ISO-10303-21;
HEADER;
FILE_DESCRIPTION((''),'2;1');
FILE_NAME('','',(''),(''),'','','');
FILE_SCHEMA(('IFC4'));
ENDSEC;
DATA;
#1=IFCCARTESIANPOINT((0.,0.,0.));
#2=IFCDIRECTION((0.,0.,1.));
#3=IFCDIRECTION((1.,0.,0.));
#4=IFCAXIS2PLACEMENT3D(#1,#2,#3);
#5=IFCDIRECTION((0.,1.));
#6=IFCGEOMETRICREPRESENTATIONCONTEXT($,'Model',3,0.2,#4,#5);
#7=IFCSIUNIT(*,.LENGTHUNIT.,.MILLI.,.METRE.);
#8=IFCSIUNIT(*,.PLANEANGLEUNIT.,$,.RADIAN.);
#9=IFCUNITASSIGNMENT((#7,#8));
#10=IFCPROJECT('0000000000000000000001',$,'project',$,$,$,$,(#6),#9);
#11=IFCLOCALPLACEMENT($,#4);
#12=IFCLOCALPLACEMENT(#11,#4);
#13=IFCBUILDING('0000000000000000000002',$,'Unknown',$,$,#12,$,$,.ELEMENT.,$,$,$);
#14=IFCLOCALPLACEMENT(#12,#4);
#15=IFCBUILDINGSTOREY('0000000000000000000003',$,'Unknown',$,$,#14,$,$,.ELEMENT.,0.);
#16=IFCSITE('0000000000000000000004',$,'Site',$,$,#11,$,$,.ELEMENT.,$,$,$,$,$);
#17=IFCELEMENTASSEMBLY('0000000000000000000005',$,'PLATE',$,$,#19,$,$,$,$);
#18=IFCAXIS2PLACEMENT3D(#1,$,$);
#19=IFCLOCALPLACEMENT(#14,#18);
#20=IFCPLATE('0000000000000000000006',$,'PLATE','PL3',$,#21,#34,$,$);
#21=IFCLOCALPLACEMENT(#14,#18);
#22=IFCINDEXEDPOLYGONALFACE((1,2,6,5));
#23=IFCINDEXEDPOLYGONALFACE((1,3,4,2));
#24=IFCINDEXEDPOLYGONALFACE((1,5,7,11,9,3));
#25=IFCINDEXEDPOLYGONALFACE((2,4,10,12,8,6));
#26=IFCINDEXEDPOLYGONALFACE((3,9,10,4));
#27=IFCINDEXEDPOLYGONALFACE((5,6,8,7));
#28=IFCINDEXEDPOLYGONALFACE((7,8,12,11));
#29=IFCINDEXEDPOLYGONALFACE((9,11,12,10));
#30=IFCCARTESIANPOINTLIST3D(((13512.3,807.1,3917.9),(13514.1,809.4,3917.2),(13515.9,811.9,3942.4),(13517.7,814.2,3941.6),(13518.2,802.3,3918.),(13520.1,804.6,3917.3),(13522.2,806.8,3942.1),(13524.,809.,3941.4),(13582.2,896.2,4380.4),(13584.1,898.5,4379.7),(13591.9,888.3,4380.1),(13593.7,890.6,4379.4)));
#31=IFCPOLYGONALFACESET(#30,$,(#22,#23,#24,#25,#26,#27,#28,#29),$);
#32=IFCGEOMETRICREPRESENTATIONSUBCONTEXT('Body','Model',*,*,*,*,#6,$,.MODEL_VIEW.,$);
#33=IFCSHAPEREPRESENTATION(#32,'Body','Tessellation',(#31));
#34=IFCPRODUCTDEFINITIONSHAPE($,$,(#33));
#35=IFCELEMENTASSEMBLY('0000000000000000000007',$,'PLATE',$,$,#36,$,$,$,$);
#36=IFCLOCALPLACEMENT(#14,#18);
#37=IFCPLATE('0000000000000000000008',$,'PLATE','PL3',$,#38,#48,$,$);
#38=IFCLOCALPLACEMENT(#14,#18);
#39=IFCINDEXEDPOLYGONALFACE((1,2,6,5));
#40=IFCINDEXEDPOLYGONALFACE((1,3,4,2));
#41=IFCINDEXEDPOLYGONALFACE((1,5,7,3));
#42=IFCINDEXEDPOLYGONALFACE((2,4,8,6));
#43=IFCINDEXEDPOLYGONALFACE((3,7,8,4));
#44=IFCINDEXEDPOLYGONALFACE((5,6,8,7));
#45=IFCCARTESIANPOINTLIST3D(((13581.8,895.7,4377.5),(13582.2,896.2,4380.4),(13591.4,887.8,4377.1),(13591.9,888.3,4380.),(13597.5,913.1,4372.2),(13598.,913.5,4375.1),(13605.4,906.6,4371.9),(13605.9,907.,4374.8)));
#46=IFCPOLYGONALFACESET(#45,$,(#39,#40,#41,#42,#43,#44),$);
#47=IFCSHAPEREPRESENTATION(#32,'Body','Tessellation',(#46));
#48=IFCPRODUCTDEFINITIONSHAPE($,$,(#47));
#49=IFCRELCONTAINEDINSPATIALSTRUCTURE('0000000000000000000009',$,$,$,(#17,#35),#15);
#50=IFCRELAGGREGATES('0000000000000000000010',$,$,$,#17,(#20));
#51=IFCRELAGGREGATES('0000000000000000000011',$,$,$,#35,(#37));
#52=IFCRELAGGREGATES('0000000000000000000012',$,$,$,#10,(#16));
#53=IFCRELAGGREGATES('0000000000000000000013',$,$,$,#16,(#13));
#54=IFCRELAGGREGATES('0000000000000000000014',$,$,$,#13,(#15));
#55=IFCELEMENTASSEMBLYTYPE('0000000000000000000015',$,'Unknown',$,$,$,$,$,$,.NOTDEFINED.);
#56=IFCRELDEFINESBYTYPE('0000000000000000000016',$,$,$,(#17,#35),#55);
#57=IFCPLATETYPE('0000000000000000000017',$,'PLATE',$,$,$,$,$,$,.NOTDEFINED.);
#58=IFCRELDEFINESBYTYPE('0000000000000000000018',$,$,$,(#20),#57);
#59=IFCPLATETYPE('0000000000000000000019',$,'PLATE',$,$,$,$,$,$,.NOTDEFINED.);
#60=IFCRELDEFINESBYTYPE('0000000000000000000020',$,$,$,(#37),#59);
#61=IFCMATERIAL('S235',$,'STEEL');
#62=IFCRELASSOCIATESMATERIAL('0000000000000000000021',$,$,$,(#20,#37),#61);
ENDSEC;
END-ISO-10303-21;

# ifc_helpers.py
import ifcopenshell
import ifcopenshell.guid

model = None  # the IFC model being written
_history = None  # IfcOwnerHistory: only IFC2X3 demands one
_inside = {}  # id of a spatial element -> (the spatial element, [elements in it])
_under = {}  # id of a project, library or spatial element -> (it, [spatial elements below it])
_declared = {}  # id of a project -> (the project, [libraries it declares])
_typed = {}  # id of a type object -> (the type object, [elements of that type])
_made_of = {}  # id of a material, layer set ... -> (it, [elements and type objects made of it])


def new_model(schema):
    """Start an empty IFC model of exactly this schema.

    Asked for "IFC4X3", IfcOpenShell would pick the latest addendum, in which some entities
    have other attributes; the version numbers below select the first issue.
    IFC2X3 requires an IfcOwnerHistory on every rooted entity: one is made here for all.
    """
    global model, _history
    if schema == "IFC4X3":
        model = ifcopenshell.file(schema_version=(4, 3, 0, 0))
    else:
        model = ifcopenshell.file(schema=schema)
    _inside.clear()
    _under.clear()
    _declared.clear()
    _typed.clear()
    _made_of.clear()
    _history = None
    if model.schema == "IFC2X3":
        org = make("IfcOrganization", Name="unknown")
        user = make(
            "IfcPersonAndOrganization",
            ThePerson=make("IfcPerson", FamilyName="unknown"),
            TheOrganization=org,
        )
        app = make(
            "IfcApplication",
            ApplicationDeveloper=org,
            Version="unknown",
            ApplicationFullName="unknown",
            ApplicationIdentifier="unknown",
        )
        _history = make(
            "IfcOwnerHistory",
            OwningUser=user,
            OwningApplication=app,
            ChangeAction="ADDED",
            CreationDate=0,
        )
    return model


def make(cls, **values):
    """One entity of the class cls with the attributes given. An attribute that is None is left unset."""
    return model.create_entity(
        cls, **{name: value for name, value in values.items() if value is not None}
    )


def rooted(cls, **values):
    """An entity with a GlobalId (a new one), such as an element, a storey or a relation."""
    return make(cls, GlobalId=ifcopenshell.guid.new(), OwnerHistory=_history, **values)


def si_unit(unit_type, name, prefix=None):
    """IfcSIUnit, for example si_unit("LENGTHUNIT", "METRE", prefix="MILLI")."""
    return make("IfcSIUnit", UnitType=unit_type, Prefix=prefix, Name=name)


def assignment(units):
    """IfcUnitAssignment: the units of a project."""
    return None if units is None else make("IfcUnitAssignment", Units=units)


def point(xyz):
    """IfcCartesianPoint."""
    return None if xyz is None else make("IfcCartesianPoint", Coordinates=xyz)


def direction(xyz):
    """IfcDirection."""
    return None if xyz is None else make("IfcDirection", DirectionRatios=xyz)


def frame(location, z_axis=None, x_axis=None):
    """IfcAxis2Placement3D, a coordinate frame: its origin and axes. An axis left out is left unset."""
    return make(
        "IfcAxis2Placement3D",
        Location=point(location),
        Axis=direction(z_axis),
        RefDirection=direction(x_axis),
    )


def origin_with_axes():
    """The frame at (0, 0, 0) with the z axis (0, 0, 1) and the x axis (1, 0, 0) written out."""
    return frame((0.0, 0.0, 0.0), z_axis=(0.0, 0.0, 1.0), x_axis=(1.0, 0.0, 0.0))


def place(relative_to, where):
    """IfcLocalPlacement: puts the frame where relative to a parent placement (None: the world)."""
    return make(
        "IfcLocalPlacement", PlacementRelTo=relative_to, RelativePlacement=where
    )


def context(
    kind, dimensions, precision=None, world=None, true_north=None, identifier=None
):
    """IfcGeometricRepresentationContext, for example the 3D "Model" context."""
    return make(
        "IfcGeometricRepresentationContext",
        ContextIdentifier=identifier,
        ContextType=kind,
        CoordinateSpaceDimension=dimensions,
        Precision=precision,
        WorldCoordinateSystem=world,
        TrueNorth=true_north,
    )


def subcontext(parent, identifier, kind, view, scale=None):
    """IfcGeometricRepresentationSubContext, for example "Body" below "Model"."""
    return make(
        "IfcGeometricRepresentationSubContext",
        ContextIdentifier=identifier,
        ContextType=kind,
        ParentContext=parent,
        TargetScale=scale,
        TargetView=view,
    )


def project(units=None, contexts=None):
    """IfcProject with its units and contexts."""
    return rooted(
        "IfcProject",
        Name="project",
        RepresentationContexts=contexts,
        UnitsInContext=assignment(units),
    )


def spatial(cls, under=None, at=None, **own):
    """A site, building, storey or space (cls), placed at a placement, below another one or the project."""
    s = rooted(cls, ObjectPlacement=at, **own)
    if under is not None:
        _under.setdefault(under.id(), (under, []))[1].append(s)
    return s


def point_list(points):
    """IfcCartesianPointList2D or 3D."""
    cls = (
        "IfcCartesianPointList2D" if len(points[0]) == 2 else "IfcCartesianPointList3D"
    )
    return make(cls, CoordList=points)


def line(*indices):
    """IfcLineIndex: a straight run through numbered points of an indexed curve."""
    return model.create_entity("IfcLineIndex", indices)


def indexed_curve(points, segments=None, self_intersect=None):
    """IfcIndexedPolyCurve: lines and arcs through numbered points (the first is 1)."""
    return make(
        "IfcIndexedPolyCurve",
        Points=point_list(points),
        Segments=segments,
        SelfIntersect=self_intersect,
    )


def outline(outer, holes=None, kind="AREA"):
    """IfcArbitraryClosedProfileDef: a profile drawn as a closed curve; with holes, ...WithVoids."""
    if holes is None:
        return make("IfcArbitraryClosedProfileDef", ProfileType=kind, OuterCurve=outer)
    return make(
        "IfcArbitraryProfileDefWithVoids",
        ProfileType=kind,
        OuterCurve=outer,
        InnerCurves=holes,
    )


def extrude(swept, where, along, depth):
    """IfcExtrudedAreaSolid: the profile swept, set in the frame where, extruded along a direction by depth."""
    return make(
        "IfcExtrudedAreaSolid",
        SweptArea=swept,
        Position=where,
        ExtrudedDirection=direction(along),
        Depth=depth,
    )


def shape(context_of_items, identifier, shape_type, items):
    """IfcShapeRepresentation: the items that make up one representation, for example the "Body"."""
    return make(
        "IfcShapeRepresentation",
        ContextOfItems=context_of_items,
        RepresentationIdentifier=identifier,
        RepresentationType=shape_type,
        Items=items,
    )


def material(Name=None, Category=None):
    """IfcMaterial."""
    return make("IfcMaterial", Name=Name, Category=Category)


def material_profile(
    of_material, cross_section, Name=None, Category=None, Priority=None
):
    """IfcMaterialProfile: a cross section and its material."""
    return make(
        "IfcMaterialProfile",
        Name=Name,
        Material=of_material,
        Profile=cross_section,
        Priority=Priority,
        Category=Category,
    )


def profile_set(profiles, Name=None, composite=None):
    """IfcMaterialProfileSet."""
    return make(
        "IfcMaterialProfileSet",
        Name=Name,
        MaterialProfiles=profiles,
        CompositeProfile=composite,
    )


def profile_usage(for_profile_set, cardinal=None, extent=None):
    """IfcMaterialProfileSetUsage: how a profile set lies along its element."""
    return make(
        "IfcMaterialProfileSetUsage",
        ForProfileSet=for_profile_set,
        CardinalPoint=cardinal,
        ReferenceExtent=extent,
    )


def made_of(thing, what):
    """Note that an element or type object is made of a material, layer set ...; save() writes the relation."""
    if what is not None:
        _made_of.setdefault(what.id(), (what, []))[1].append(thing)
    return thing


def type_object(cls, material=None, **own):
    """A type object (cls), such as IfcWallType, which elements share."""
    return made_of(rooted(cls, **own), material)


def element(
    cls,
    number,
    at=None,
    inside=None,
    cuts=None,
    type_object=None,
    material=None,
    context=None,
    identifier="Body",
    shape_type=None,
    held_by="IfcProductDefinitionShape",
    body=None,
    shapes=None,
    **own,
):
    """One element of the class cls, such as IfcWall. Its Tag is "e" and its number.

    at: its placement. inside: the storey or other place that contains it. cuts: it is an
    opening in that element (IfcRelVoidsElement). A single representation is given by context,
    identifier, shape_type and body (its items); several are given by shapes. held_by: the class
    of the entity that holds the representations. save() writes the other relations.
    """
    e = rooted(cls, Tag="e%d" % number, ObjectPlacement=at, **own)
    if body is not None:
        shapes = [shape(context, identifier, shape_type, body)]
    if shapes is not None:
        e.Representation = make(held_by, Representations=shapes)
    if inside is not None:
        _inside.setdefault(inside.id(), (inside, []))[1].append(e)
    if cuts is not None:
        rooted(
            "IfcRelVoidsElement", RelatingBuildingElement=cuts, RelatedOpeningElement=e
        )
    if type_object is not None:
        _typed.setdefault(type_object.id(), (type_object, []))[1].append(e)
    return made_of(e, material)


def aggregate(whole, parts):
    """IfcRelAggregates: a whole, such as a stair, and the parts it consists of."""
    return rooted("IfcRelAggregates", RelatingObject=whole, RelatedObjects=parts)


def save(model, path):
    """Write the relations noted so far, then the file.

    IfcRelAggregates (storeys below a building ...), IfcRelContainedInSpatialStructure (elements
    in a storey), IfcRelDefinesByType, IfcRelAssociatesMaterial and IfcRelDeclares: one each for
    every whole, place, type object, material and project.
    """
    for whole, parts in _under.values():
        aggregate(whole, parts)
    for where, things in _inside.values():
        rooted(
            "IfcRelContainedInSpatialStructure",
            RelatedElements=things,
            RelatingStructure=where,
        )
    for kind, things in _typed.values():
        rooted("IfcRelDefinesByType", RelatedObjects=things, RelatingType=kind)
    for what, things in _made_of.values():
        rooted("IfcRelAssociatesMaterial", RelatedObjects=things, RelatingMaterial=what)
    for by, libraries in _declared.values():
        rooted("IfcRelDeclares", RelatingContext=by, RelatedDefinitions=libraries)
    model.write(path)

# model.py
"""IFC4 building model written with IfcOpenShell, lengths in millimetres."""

from ifc_helpers import new_model, si_unit, direction, frame, origin_with_axes, place, context, subcontext, project, spatial, line, indexed_curve, outline, extrude, material, material_profile, profile_set, profile_usage, type_object, element, aggregate, save


model = new_model("IFC4")

# Units and contexts
model_context = context("Model", 3, precision=0.2, world=origin_with_axes(), true_north=direction((0.0, 1.0)))
body_context = subcontext(model_context, "Body", "Model", "MODEL_VIEW")
ifc_project = project(units=[si_unit("LENGTHUNIT", "METRE", prefix="MILLI"), si_unit("PLANEANGLEUNIT", "RADIAN")], contexts=[model_context])

# Site, building, storey
site_placement = place(None, origin_with_axes())
site = spatial("IfcSite", under=ifc_project, at=site_placement, Name="Site", CompositionType="ELEMENT")
building_placement = place(site_placement, origin_with_axes())
building = spatial("IfcBuilding", under=site, at=building_placement, Name="Unknown", CompositionType="ELEMENT")
storey_placement = place(building_placement, origin_with_axes())
storey = spatial("IfcBuildingStorey", under=building, at=storey_placement, Name="Unknown", CompositionType="ELEMENT", Elevation=0.0)

# Shared definitions
element_assembly_type = type_object("IfcElementAssemblyType", Name="Unknown", PredefinedType="NOTDEFINED")

# Shared definitions
ifc_material_1 = material(Name="S235", Category="STEEL")

# Element assemblies, plates
assembly_1_placement = place(storey_placement, frame((13592.8, 889.4, 4379.7), z_axis=(-0.610976, -0.75508, 0.237831), x_axis=(-0.773667, 0.633184, 0.022757)))
assembly_1 = element("IfcElementAssembly", 1, at=assembly_1_placement, inside=storey, type_object=element_assembly_type, Name="PLATE")
ifc_material_profile_1 = material_profile(ifc_material_1, outline(indexed_curve([(0.0, 0.0), (12.5, 0.0), (0.5, 450.8), (-0.3, 475.9), (-8.0, 475.7), (-7.7, 450.9)], segments=[line(1, 2, 3, 4, 5, 6, 1)])), Name="PL3")
ifc_profile_set_1 = profile_set([ifc_material_profile_1])
ifc_profile_usage_1 = profile_usage(ifc_profile_set_1, cardinal=5)
plate_type_1 = type_object("IfcPlateType", Name="PLATE", PredefinedType="NOTDEFINED")
plate_1_placement = place(assembly_1_placement, origin_with_axes())
plate_1 = element("IfcPlate", 2, at=plate_1_placement, type_object=plate_type_1, material=ifc_profile_usage_1, Name="PLATE", Description="PL3", context=body_context, shape_type="SolidModel", body=[
    extrude(outline(indexed_curve([(0.0, 0.0), (12.5, 0.0), (0.5, 450.8), (-0.3, 475.9), (-8.0, 475.7), (-7.7, 450.9)], segments=[line(1, 2, 3, 4, 5, 6, 1)])), frame((0.0, 0.0, 1.5), z_axis=(0.0, 0.0, 1.0), x_axis=(1.0, 0.0, 0.0)), (0.0, 0.0, -1.0), 3.0),
])
aggregate(assembly_1, [plate_1])
assembly_2_placement = place(storey_placement, frame((13597.7, 913.3, 4373.7), z_axis=(0.159593, 0.150478, 0.975647), x_axis=(-0.656061, -0.722318, 0.218722)))
assembly_2 = element("IfcElementAssembly", 3, at=assembly_2_placement, inside=storey, type_object=element_assembly_type, Name="PLATE")
ifc_material_profile_2 = material_profile(ifc_material_1, outline(indexed_curve([(0.0, 0.0), (24.0, 0.0), (23.3, 12.4), (-0.6, 10.2)], segments=[line(1, 2, 3, 4, 1)])), Name="PL3")
ifc_profile_set_2 = profile_set([ifc_material_profile_2])
ifc_profile_usage_2 = profile_usage(ifc_profile_set_2, cardinal=5)
plate_type_2 = type_object("IfcPlateType", Name="PLATE", PredefinedType="NOTDEFINED")
plate_2_placement = place(assembly_2_placement, origin_with_axes())
plate_2 = element("IfcPlate", 4, at=plate_2_placement, type_object=plate_type_2, material=ifc_profile_usage_2, Name="PLATE", Description="PL3", context=body_context, shape_type="SolidModel", body=[
    extrude(outline(indexed_curve([(0.0, 0.0), (24.0, 0.0), (23.3, 12.4), (-0.6, 10.2)], segments=[line(1, 2, 3, 4, 1)])), frame((0.0, 0.0, 1.5), z_axis=(0.0, 0.0, 1.0), x_axis=(1.0, 0.0, 0.0)), (0.0, 0.0, -1.0), 3.0),
])
aggregate(assembly_2, [plate_2])

save(model, "model.ifc")
